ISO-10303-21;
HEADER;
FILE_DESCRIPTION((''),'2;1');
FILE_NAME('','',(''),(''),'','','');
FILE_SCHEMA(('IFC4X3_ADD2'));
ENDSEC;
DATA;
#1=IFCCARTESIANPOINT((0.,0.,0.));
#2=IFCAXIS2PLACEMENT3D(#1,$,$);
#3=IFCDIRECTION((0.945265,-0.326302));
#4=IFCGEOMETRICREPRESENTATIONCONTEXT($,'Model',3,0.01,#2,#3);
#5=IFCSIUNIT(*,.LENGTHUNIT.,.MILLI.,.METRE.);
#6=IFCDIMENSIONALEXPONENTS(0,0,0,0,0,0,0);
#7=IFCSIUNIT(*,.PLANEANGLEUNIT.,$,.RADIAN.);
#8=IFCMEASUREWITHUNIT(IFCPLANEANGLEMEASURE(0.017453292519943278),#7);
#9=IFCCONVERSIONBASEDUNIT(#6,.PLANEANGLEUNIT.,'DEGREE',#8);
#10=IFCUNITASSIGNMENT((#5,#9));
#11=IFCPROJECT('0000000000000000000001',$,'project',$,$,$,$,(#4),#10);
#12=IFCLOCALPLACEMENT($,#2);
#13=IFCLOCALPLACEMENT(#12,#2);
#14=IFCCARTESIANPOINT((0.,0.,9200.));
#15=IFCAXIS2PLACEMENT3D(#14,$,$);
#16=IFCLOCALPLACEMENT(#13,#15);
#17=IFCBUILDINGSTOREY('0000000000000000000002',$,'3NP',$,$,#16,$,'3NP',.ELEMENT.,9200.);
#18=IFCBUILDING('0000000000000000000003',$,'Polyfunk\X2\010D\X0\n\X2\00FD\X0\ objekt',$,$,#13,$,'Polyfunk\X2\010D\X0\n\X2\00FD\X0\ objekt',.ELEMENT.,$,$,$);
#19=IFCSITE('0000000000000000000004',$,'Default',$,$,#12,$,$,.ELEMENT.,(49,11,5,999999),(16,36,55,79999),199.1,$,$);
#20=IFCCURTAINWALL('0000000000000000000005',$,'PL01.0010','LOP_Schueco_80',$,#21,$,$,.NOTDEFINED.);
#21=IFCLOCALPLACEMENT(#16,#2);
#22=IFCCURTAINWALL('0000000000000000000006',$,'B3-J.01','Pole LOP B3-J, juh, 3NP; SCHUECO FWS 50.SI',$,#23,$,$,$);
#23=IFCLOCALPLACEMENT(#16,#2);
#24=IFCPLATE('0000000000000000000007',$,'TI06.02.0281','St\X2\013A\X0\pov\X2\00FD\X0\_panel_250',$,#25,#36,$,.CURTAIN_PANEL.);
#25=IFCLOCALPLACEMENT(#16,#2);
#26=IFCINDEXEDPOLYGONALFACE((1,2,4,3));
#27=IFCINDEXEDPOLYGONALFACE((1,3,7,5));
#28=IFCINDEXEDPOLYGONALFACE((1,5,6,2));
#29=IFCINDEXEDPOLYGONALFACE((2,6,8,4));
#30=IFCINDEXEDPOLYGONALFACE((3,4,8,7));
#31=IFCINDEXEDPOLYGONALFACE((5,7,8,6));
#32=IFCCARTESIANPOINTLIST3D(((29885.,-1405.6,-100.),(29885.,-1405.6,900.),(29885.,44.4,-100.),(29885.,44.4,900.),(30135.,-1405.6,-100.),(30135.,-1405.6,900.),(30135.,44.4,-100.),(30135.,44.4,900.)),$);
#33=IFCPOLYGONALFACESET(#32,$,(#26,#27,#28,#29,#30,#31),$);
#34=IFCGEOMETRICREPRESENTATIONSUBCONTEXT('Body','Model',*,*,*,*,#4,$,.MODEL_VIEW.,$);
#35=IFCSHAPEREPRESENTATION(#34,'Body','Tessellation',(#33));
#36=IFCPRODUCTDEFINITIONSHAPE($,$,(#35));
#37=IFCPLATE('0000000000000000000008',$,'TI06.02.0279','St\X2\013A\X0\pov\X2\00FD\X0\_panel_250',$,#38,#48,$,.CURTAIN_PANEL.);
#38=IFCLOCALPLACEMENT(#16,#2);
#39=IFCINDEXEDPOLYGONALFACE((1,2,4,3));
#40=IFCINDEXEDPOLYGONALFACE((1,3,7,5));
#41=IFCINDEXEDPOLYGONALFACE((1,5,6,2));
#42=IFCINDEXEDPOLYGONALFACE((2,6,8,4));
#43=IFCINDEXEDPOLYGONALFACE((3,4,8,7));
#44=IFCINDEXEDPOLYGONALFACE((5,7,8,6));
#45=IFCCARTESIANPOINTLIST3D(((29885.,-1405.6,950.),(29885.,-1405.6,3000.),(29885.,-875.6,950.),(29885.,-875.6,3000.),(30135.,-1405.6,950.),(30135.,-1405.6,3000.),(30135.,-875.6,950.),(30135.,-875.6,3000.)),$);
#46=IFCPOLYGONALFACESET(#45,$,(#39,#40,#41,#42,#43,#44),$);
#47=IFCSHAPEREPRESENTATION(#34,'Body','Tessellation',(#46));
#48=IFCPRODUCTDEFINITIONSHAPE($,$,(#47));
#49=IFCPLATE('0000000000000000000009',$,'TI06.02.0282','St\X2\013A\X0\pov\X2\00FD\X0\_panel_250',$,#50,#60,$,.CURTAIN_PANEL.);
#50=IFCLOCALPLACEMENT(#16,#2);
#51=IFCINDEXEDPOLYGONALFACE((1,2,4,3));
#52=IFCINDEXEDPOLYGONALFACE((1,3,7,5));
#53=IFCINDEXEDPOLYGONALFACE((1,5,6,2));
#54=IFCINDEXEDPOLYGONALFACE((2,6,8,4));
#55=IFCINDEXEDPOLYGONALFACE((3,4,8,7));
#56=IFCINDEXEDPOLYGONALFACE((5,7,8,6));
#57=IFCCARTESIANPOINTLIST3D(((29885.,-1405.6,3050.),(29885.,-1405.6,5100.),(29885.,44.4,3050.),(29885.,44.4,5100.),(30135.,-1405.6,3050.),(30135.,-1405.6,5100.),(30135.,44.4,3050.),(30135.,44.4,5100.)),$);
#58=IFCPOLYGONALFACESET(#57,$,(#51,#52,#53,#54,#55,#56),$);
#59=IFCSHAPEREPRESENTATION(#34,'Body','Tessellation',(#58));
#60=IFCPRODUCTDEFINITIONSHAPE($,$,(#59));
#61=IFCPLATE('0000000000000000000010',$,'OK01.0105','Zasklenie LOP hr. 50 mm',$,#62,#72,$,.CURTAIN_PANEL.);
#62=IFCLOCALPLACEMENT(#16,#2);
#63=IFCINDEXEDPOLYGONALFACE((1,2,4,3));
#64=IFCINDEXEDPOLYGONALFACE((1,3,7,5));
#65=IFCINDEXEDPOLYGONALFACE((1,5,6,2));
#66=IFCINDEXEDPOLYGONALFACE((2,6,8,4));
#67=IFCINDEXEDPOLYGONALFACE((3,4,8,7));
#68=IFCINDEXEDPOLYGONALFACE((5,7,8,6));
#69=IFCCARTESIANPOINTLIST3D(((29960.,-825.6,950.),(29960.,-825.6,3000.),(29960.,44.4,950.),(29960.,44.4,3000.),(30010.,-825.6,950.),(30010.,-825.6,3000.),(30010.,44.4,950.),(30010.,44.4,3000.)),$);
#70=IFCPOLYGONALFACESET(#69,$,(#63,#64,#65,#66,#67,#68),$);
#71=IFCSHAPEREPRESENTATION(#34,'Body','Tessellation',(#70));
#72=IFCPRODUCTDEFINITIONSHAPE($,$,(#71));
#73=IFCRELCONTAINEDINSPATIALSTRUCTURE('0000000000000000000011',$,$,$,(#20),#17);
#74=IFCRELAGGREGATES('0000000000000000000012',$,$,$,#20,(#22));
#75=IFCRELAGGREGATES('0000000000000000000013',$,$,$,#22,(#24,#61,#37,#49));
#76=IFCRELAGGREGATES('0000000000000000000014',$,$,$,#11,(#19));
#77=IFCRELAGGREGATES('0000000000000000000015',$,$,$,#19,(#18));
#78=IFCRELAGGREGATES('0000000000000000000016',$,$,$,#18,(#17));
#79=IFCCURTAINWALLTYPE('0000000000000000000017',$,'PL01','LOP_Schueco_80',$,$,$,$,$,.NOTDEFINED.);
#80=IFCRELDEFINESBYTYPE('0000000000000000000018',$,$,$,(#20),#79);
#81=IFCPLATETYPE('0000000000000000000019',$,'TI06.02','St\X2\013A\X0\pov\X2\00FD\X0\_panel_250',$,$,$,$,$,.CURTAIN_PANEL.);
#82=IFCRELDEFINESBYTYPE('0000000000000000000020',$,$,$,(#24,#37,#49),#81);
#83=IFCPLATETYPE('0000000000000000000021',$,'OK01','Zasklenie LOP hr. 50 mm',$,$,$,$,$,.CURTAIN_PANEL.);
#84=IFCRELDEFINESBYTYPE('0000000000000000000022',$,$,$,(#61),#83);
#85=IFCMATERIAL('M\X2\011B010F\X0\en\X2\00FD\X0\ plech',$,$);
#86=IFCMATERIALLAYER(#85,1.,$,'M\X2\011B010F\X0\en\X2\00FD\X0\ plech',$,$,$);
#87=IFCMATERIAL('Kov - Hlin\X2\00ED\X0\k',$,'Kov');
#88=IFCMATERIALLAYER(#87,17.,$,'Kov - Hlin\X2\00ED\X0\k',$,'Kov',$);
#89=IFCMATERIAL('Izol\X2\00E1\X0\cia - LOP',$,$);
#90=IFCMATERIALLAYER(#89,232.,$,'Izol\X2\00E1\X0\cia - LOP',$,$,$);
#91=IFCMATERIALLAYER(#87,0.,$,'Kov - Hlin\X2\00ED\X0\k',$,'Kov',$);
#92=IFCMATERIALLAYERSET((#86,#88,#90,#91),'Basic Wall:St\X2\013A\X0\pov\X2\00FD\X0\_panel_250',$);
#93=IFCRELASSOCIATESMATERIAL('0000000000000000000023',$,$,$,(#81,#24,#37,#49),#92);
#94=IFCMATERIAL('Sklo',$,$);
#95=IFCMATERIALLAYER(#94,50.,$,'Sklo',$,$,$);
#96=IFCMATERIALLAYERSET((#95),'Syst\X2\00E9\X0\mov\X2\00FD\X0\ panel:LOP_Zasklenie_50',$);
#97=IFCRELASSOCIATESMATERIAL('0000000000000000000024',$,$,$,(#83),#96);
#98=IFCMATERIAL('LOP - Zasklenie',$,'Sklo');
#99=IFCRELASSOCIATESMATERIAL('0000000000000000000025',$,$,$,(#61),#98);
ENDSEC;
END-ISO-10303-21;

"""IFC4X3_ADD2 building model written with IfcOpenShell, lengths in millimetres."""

from ifc_helpers import new_model, entity, si_unit, converted_unit, direction, frame, frame_2d, origin, origin_2d_with_axis, place, context, subcontext, project, spatial, rectangle, extrude, source, transform, mapped, material, layer, layer_set, layer_usage, type_object, type_shapes, element, aggregate, save


model = new_model("IFC4X3_ADD2")

# Units and contexts
model_context = context("Model", 3, precision=0.01, world=origin(), true_north=direction((0.945265, -0.326302)))
body_context = subcontext(model_context, "Body", "Model", "MODEL_VIEW")
ifc_project = project(units=[si_unit("LENGTHUNIT", "METRE", prefix="MILLI"), converted_unit("PLANEANGLEUNIT", "DEGREE", entity("IfcPlaneAngleMeasure", 0.017453292519943278), si_unit("PLANEANGLEUNIT", "RADIAN"), dimensions=[0, 0, 0, 0, 0, 0, 0])], contexts=[model_context])

# Site, building, storey
site_placement = place(None, origin())
site = spatial("IfcSite", under=ifc_project, at=site_placement, Name="Default", CompositionType="ELEMENT", RefLatitude=(49, 11, 5, 999999), RefLongitude=(16, 36, 55, 79999), RefElevation=199.1)
building_placement = place(site_placement, origin())
building = spatial("IfcBuilding", under=site, at=building_placement, Name="Polyfunkčný objekt", LongName="Polyfunkčný objekt", CompositionType="ELEMENT")
storey_placement = place(building_placement, frame((0.0, 0.0, 9200.0)))
storey = spatial("IfcBuildingStorey", under=building, at=storey_placement, Name="3NP", LongName="3NP", CompositionType="ELEMENT", Elevation=9200.0)

# Curtain walls, plates
curtain_wall_type = type_object("IfcCurtainWallType", Name="PL01", Description="LOP_Schueco_80", PredefinedType="NOTDEFINED")
curtain_wall_1_placement = place(storey_placement, frame((0.0, 0.0, -9200.0)))
curtain_wall_1 = element("IfcCurtainWall", 1, at=curtain_wall_1_placement, inside=storey, type_object=curtain_wall_type, Name="PL01.0010", Description="LOP_Schueco_80", PredefinedType="NOTDEFINED")
curtain_wall_2 = element("IfcCurtainWall", 2, Name="B3-J.01", Description="Pole LOP B3-J, juh, 3NP; SCHUECO FWS 50.SI")
aggregate(curtain_wall_1, [curtain_wall_2])
ifc_material_1 = material(Name="Měďený plech")
ifc_layer_1 = layer(ifc_material_1, 1.0, Name="Měďený plech")
ifc_material_2 = material(Name="Kov - Hliník", Category="Kov")
ifc_layer_2 = layer(ifc_material_2, 17.0, Name="Kov - Hliník", Category="Kov")
ifc_material_3 = material(Name="Izolácia - LOP")
ifc_layer_3 = layer(ifc_material_3, 232.0, Name="Izolácia - LOP")
ifc_layer_4 = layer(ifc_material_2, 0.0, Name="Kov - Hliník", Category="Kov")
ifc_layer_set_1 = layer_set([ifc_layer_1, ifc_layer_2, ifc_layer_3, ifc_layer_4], Name="Basic Wall:Stĺpový_panel_250")
ifc_layer_usage_1 = layer_usage(ifc_layer_set_1, "AXIS2", "POSITIVE", -125.0)
plate_type_1 = type_object("IfcPlateType", Name="TI06.02", Description="Stĺpový_panel_250", PredefinedType="CURTAIN_PANEL", material=ifc_layer_set_1)
plate_1_placement = place(storey_placement, frame((30010.0, 44.4, -100.0), z_axis=(0.0, 0.0, 1.0), x_axis=(0.0, -1.0, 0.0)))
plate_1 = element("IfcPlate", 3, at=plate_1_placement, type_object=plate_type_1, material=ifc_layer_usage_1, Name="TI06.02.0281", Description="Stĺpový_panel_250", PredefinedType="CURTAIN_PANEL", context=body_context, shape_type="SweptSolid", body=[
    extrude(rectangle(XDim=250.0, YDim=1450.0, at=frame_2d((0.0, 0.0), x_axis=(1.0, 0.0))), frame((725.0, 0.0, 0.0), z_axis=(0.0, 0.0, 1.0), x_axis=(0.0, 1.0, 0.0)), (0.0, 0.0, 1.0), 1000.0),
])
ifc_layer_usage_2 = layer_usage(ifc_layer_set_1, "AXIS2", "POSITIVE", -125.0)
plate_2_placement = place(storey_placement, frame((30010.0, -875.6, 950.0), z_axis=(0.0, 0.0, 1.0), x_axis=(0.0, -1.0, 0.0)))
plate_2 = element("IfcPlate", 4, at=plate_2_placement, type_object=plate_type_1, material=ifc_layer_usage_2, Name="TI06.02.0279", Description="Stĺpový_panel_250", PredefinedType="CURTAIN_PANEL", context=body_context, shape_type="SweptSolid", body=[
    extrude(rectangle(XDim=250.0, YDim=530.0, at=frame_2d((0.0, 0.0), x_axis=(1.0, 0.0))), frame((265.0, 0.0, 0.0), z_axis=(0.0, 0.0, 1.0), x_axis=(0.0, 1.0, 0.0)), (0.0, 0.0, 1.0), 2050.0),
])
ifc_layer_usage_3 = layer_usage(ifc_layer_set_1, "AXIS2", "POSITIVE", -125.0)
plate_3_placement = place(storey_placement, frame((30010.0, 44.4, 3050.0), z_axis=(0.0, 0.0, 1.0), x_axis=(0.0, -1.0, 0.0)))
plate_3 = element("IfcPlate", 5, at=plate_3_placement, type_object=plate_type_1, material=ifc_layer_usage_3, Name="TI06.02.0282", Description="Stĺpový_panel_250", PredefinedType="CURTAIN_PANEL", context=body_context, shape_type="SweptSolid", body=[
    extrude(rectangle(XDim=250.0, YDim=1450.0, at=frame_2d((0.0, 0.0), x_axis=(1.0, 0.0))), frame((725.0, 0.0, 0.0), z_axis=(0.0, 0.0, 1.0), x_axis=(0.0, 1.0, 0.0)), (0.0, 0.0, 1.0), 2050.0),
])
ifc_material_4 = material(Name="LOP - Zasklenie", Category="Sklo")
ifc_material_5 = material(Name="Sklo")
ifc_layer_5 = layer(ifc_material_5, 50.0, Name="Sklo")
ifc_layer_set_2 = layer_set([ifc_layer_5], Name="Systémový panel:LOP_Zasklenie_50")
plate_type_2 = type_object("IfcPlateType", Name="OK01", Description="Zasklenie LOP hr. 50 mm", PredefinedType="CURTAIN_PANEL", material=ifc_layer_set_2)
shared_shape_1 = source(origin(), body_context, "Body", "SweptSolid", [
    extrude(rectangle(XDim=50.0, YDim=870.0, at=origin_2d_with_axis()), frame((0.0, -25.0, 0.0), z_axis=(0.0, 0.0, 1.0), x_axis=(0.0, 1.0, 0.0)), (0.0, 0.0, 1.0), 2050.0),
])
type_shapes(plate_type_2, [shared_shape_1])
plate_4_placement = place(curtain_wall_1_placement, frame((30010.0, -390.6, 10150.0), z_axis=(0.0, 0.0, 1.0), x_axis=(0.0, -1.0, 0.0)))
plate_4 = element("IfcPlate", 6, at=plate_4_placement, type_object=plate_type_2, material=ifc_material_4, Name="OK01.0105", Description="Zasklenie LOP hr. 50 mm", PredefinedType="CURTAIN_PANEL", context=body_context, shape_type="MappedRepresentation", body=[
    mapped(shared_shape_1, transform((0.0, 0.0, 0.0), scale=1.0)),
])
aggregate(curtain_wall_2, [plate_1, plate_4, plate_2, plate_3])

save(model, "model.ifc")
